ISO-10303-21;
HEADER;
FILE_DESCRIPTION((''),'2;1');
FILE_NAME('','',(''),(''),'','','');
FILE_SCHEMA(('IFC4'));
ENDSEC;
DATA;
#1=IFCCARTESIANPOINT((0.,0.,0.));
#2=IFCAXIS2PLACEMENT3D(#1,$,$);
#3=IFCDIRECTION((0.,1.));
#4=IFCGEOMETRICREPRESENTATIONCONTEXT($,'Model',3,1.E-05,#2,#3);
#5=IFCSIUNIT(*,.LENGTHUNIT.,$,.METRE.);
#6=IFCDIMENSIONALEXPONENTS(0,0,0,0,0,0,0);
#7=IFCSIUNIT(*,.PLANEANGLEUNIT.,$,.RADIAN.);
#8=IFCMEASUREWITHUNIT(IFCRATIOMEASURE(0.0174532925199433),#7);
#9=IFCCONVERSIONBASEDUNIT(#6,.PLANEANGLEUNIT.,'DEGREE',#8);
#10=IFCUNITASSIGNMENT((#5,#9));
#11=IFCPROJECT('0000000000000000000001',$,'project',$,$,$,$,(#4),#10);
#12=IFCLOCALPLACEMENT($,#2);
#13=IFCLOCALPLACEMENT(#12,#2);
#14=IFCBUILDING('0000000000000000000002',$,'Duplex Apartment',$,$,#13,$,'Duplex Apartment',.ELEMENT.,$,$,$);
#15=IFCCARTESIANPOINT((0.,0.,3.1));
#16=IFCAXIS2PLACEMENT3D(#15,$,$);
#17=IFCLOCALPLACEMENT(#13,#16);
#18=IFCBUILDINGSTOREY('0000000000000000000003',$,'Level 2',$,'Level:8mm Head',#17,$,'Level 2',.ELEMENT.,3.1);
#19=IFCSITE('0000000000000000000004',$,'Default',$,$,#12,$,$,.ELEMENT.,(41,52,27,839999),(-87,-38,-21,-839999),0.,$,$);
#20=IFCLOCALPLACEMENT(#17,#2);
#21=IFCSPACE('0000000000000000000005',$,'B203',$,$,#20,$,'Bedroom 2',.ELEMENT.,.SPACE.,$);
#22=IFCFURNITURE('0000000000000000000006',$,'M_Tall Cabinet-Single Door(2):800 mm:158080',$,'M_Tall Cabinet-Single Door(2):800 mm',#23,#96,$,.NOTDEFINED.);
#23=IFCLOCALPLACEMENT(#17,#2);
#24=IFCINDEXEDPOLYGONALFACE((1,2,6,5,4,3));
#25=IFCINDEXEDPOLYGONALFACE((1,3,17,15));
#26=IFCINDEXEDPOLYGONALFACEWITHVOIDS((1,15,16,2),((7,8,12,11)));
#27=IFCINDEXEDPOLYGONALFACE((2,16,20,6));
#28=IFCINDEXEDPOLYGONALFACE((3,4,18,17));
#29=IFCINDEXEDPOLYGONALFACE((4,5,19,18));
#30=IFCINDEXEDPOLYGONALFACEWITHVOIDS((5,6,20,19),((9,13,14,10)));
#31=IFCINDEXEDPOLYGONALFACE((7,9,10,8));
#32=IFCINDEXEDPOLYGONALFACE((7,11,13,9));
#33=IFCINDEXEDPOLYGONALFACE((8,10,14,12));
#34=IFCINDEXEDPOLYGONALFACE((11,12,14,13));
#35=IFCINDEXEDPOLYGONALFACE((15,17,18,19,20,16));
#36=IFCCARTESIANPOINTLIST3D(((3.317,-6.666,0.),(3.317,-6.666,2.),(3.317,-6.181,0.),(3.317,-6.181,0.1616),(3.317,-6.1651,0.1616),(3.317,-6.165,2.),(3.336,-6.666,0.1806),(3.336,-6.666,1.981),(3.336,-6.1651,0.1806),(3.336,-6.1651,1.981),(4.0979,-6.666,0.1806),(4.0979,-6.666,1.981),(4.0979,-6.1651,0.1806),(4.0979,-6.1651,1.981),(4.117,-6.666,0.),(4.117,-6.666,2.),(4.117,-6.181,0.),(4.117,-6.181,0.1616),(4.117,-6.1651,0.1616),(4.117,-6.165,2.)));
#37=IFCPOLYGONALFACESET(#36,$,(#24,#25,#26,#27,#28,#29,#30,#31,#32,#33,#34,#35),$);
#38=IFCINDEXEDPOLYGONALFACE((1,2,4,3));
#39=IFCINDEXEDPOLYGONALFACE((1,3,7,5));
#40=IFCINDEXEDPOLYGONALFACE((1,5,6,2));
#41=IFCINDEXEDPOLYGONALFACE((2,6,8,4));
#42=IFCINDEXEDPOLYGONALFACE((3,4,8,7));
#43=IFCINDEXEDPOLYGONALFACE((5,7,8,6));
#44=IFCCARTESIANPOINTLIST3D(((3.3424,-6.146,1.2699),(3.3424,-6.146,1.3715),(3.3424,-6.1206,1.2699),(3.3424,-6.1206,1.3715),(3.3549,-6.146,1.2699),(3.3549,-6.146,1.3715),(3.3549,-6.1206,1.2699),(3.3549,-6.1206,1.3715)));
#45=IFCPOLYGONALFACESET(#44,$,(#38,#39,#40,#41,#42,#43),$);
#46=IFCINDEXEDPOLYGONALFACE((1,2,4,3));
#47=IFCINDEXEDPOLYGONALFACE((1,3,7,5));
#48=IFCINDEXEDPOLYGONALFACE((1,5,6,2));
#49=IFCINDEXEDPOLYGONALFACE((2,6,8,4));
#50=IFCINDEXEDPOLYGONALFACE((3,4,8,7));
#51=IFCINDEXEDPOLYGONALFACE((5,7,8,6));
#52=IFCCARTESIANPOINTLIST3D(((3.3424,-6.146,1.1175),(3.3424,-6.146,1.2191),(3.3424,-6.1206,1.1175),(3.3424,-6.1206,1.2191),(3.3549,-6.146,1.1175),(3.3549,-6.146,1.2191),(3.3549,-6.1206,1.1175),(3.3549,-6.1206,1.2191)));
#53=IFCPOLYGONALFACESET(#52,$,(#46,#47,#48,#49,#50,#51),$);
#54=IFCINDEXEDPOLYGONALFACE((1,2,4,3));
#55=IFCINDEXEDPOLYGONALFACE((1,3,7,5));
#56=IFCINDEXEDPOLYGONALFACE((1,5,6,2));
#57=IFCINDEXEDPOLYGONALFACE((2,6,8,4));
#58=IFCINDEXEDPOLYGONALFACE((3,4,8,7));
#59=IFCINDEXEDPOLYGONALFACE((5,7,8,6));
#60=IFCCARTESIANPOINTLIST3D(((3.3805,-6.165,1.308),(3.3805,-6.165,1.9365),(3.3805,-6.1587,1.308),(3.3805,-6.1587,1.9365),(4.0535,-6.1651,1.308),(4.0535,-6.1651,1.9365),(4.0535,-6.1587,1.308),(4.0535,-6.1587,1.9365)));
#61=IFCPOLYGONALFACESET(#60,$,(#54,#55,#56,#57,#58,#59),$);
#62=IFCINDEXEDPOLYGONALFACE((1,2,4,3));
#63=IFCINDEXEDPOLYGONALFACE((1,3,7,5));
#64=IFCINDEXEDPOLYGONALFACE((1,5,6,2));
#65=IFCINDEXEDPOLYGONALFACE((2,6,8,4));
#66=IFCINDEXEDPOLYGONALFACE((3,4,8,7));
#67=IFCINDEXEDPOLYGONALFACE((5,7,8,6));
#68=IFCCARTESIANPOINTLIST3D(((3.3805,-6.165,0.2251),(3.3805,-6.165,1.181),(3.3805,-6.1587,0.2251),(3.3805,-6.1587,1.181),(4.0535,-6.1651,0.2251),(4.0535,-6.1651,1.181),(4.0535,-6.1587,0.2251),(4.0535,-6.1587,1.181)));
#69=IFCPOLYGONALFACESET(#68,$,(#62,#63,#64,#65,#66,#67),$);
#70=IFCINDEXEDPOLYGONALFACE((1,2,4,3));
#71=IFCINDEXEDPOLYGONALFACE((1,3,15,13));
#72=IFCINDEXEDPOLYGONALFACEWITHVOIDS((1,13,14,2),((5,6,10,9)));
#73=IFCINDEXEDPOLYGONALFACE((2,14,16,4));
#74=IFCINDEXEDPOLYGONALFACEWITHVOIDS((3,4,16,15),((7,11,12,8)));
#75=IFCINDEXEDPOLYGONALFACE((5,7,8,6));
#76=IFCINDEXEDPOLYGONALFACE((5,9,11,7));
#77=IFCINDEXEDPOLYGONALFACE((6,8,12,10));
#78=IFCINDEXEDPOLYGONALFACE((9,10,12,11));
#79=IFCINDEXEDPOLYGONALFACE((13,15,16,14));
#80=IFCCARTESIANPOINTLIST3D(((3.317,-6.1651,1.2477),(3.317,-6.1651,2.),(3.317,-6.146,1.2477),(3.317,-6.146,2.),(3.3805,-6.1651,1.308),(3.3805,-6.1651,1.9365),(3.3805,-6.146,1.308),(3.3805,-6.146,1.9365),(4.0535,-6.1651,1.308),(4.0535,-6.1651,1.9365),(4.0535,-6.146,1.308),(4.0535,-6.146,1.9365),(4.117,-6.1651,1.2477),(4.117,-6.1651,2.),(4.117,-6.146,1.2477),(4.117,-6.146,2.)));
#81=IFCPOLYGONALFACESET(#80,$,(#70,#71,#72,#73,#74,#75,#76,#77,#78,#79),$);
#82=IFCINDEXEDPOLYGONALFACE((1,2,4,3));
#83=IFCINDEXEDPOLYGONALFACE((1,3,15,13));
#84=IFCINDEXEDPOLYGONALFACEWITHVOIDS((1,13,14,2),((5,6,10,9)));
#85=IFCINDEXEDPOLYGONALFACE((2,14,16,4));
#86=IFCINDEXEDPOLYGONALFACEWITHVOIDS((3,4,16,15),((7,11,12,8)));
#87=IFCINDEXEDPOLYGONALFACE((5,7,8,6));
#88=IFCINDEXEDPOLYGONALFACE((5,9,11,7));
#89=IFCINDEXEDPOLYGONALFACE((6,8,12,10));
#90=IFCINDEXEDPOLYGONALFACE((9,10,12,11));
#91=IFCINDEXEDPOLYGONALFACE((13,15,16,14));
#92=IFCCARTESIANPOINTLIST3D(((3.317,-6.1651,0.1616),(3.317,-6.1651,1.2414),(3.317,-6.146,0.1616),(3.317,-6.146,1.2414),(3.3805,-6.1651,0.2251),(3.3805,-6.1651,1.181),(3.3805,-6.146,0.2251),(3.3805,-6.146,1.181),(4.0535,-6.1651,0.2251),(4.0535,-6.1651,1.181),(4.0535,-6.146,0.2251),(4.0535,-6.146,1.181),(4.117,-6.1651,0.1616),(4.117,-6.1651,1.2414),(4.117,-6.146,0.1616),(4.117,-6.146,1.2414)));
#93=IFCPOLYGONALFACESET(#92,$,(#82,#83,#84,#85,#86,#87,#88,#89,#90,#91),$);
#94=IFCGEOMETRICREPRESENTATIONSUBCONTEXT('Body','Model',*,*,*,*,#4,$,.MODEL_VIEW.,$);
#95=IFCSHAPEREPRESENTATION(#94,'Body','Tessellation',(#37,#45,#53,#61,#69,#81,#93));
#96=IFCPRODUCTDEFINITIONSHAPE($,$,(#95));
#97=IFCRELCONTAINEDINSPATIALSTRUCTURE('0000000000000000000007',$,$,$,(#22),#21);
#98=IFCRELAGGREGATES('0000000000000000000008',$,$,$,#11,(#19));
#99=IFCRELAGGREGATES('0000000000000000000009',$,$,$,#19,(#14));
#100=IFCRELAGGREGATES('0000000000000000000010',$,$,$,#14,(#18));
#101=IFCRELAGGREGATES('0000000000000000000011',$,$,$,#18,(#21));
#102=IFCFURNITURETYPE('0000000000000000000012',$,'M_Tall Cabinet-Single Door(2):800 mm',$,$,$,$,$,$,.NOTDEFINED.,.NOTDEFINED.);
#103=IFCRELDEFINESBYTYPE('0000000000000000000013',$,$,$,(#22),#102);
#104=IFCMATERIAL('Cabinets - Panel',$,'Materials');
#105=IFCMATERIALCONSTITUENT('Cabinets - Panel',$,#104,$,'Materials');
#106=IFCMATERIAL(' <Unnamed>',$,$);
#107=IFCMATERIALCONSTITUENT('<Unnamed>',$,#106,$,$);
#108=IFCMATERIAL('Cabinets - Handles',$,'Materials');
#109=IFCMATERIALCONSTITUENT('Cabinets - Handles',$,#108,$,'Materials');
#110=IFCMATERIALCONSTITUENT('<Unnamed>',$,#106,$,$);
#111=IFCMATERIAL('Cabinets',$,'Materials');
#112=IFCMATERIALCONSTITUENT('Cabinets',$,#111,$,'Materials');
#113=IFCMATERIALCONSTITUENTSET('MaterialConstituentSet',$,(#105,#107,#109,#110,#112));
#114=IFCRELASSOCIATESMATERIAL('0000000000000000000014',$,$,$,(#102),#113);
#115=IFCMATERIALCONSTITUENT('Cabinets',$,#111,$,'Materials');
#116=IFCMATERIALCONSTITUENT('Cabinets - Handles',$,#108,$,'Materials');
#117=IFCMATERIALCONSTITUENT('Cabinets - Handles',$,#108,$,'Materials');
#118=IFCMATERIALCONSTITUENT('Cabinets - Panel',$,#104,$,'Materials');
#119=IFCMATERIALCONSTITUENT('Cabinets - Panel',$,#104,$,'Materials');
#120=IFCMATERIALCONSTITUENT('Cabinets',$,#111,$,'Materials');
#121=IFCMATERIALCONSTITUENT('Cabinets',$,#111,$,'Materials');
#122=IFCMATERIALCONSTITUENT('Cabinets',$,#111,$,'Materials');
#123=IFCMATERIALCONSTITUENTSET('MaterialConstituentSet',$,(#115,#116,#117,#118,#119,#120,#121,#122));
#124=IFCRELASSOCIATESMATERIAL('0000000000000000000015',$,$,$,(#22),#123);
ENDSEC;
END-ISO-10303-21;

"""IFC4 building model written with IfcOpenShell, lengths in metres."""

from ifc_helpers import new_model, entity, si_unit, converted_unit, direction, frame, origin, place, context, subcontext, project, spatial, indexed_curve, outline, extrude, source, transform, mapped, material, constituent, constituent_set, type_object, type_shapes, element, save


model = new_model("IFC4")

# Units and contexts
model_context = context("Model", 3, precision=1e-05, world=origin(), true_north=direction((0.0, 1.0)))
body_context = subcontext(model_context, "Body", "Model", "MODEL_VIEW")
ifc_project = project(units=[si_unit("LENGTHUNIT", "METRE"), converted_unit("PLANEANGLEUNIT", "DEGREE", entity("IfcRatioMeasure", 0.0174532925199433), si_unit("PLANEANGLEUNIT", "RADIAN"), dimensions=[0, 0, 0, 0, 0, 0, 0])], contexts=[model_context])

# Site, building, storey
site_placement = place(None, origin())
site = spatial("IfcSite", under=ifc_project, at=site_placement, Name="Default", CompositionType="ELEMENT", RefLatitude=(41, 52, 27, 839999), RefLongitude=(-87, -38, -21, -839999), RefElevation=0.0)
building_placement = place(site_placement, origin())
building = spatial("IfcBuilding", under=site, at=building_placement, Name="Duplex Apartment", LongName="Duplex Apartment", CompositionType="ELEMENT")
storey_placement = place(building_placement, frame((0.0, 0.0, 3.1)))
storey = spatial("IfcBuildingStorey", under=building, at=storey_placement, Name="Level 2", ObjectType="Level:8mm Head", LongName="Level 2", CompositionType="ELEMENT", Elevation=3.1)

# Shared definitions
ifc_material_1 = material(Name="Cabinets", Category="Materials")
ifc_material_2 = material(Name="Cabinets - Handles", Category="Materials")
ifc_material_3 = material(Name="Cabinets - Panel", Category="Materials")
ifc_material_4 = material(Name=" <Unnamed>")

# Shared definitions
space_1_placement = place(storey_placement, origin())
space_1 = spatial("IfcSpace", under=storey, at=space_1_placement, Name="B203", LongName="Bedroom 2", CompositionType="ELEMENT", PredefinedType="SPACE")

# Furniture, opening
ifc_constituent_1 = constituent(ifc_material_1, Name="Cabinets", Category="Materials")
ifc_constituent_2 = constituent(ifc_material_2, Name="Cabinets - Handles", Category="Materials")
ifc_constituent_3 = constituent(ifc_material_2, Name="Cabinets - Handles", Category="Materials")
ifc_constituent_4 = constituent(ifc_material_3, Name="Cabinets - Panel", Category="Materials")
ifc_constituent_5 = constituent(ifc_material_3, Name="Cabinets - Panel", Category="Materials")
ifc_constituent_6 = constituent(ifc_material_1, Name="Cabinets", Category="Materials")
ifc_constituent_7 = constituent(ifc_material_1, Name="Cabinets", Category="Materials")
ifc_constituent_8 = constituent(ifc_material_1, Name="Cabinets", Category="Materials")
ifc_constituent_set_1 = constituent_set(constituents=[ifc_constituent_1, ifc_constituent_2, ifc_constituent_3, ifc_constituent_4, ifc_constituent_5, ifc_constituent_6, ifc_constituent_7, ifc_constituent_8], Name="MaterialConstituentSet")
ifc_constituent_9 = constituent(ifc_material_3, Name="Cabinets - Panel", Category="Materials")
ifc_constituent_10 = constituent(ifc_material_4, Name="<Unnamed>")
ifc_constituent_11 = constituent(ifc_material_2, Name="Cabinets - Handles", Category="Materials")
ifc_constituent_12 = constituent(ifc_material_4, Name="<Unnamed>")
ifc_constituent_13 = constituent(ifc_material_1, Name="Cabinets", Category="Materials")
ifc_constituent_set_2 = constituent_set(constituents=[ifc_constituent_9, ifc_constituent_10, ifc_constituent_11, ifc_constituent_12, ifc_constituent_13], Name="MaterialConstituentSet")
furniture_type_1 = type_object("IfcFurnitureType", Name="M_Tall Cabinet-Single Door(2):800 mm", AssemblyPlace="NOTDEFINED", PredefinedType="NOTDEFINED", material=ifc_constituent_set_2)
shared_shape_1 = source(origin(), body_context, "Body", "SweptSolid", [
    extrude(outline(indexed_curve([(-0.1723, 0.5589), (-0.1723, -1.2795), (0.3286, -1.2795), (0.3287, 0.7205), (-0.1563, 0.7205), (-0.1563, 0.5589), (-0.1723, 0.5589)], self_intersect=False)), frame((-0.3813, -0.3286, 0.7205), z_axis=(-1.0, 0.0, 0.0), x_axis=(0.0, 1.0, 0.0)), (0.0, 0.0, -1.0), 0.8),
    extrude(outline(indexed_curve([(-0.0127, -0.0063), (0.0127, -0.0063), (0.0127, 0.0063), (-0.0127, 0.0063), (-0.0127, -0.0063)], self_intersect=False)), frame((0.3871, -0.5327, 1.2699), z_axis=(0.0, 0.0, 1.0), x_axis=(0.0, 1.0, 0.0)), (0.0, 0.0, 1.0), 0.1016),
    extrude(outline(indexed_curve([(-0.0127, -0.0063), (0.0127, -0.0063), (0.0127, 0.0063), (-0.0127, 0.0063), (-0.0127, -0.0063)], self_intersect=False)), frame((0.3871, -0.5327, 1.1175), z_axis=(0.0, 0.0, 1.0), x_axis=(0.0, 1.0, 0.0)), (0.0, 0.0, 1.0), 0.1016),
    extrude(outline(indexed_curve([(-0.0032, -0.3365), (0.0032, -0.3365), (0.0032, 0.3365), (-0.0032, 0.3365), (-0.0032, -0.3365)], self_intersect=False)), frame((0.0187, -0.5041, 1.308), z_axis=(0.0, 0.0, 1.0), x_axis=(0.0, 1.0, 0.0)), (0.0, 0.0, 1.0), 0.6285),
    extrude(outline(indexed_curve([(-0.0032, -0.3365), (0.0032, -0.3365), (0.0032, 0.3365), (-0.0032, 0.3365), (-0.0032, -0.3365)], self_intersect=False)), frame((0.0187, -0.5041, 0.2251), z_axis=(0.0, 0.0, 1.0), x_axis=(0.0, 1.0, 0.0)), (0.0, 0.0, 1.0), 0.956),
    extrude(outline(indexed_curve([(-0.3761, -0.4), (0.3761, -0.4), (0.3761, 0.4), (-0.3761, 0.4), (-0.3761, -0.4)], self_intersect=False), holes=[indexed_curve([(-0.3126, -0.3365), (-0.3126, 0.3365), (0.3158, 0.3365), (0.3158, -0.3365), (-0.3126, -0.3365)], self_intersect=False)]), frame((0.0187, -0.52, 1.6239), z_axis=(0.0, 1.0, 0.0), x_axis=(0.0, 0.0, -1.0)), (0.0, 0.0, 1.0), 0.0191),
    extrude(outline(indexed_curve([(-0.4, -0.5399), (0.4, -0.5399), (0.4, 0.5399), (-0.4, 0.5399), (-0.4, -0.5399)], self_intersect=False), holes=[indexed_curve([(-0.3365, 0.4796), (0.3365, 0.4796), (0.3365, -0.4764), (-0.3365, -0.4764), (-0.3365, 0.4796)], self_intersect=False)]), frame((0.0187, -0.52, 0.7015), z_axis=(0.0, 1.0, 0.0), x_axis=(-1.0, 0.0, 0.0)), (0.0, 0.0, 1.0), 0.0191),
    extrude(outline(indexed_curve([(-0.0095, -0.381), (0.0095, -0.381), (0.0095, 0.381), (-0.0095, 0.381), (-0.0095, -0.381)], self_intersect=False)), frame((0.0187, -0.0095, 0.1806), z_axis=(0.0, 0.0, 1.0), x_axis=(0.0, 1.0, 0.0)), (0.0, 0.0, 1.0), 1.8003),
])
type_shapes(furniture_type_1, [shared_shape_1])
furniture_1_placement = place(space_1_placement, frame((3.7357, -6.666, 0.0), z_axis=(0.0, 0.0, 1.0), x_axis=(-1.0, 0.0, 0.0)))
furniture_1 = element("IfcFurniture", 1, at=furniture_1_placement, inside=space_1, type_object=furniture_type_1, material=ifc_constituent_set_1, Name="M_Tall Cabinet-Single Door(2):800 mm:158080", ObjectType="M_Tall Cabinet-Single Door(2):800 mm", PredefinedType="NOTDEFINED", context=body_context, shape_type="MappedRepresentation", body=[
    mapped(shared_shape_1, transform((0.0, 0.0, 0.0), scale=1.0)),
])
opening_1_placement = place(storey_placement, frame((3.7357, -6.666, 3.1)))
element("IfcOpeningElement", 2, at=opening_1_placement, cuts=furniture_1, ObjectType="Opening", PredefinedType="OPENING", context=body_context, shape_type="SweptSolid", body=[
    extrude(outline(indexed_curve([(-0.381, -0.9002), (0.381, -0.9002), (0.381, 0.9002), (-0.381, 0.9002), (-0.381, -0.9002)], self_intersect=False)), frame((-0.0187, 0.0, -2.0192), z_axis=(0.0, 1.0, 0.0), x_axis=(1.0, 0.0, 0.0)), (0.0, 0.0, 1.0), 0.501),
])

save(model, "model.ifc")
